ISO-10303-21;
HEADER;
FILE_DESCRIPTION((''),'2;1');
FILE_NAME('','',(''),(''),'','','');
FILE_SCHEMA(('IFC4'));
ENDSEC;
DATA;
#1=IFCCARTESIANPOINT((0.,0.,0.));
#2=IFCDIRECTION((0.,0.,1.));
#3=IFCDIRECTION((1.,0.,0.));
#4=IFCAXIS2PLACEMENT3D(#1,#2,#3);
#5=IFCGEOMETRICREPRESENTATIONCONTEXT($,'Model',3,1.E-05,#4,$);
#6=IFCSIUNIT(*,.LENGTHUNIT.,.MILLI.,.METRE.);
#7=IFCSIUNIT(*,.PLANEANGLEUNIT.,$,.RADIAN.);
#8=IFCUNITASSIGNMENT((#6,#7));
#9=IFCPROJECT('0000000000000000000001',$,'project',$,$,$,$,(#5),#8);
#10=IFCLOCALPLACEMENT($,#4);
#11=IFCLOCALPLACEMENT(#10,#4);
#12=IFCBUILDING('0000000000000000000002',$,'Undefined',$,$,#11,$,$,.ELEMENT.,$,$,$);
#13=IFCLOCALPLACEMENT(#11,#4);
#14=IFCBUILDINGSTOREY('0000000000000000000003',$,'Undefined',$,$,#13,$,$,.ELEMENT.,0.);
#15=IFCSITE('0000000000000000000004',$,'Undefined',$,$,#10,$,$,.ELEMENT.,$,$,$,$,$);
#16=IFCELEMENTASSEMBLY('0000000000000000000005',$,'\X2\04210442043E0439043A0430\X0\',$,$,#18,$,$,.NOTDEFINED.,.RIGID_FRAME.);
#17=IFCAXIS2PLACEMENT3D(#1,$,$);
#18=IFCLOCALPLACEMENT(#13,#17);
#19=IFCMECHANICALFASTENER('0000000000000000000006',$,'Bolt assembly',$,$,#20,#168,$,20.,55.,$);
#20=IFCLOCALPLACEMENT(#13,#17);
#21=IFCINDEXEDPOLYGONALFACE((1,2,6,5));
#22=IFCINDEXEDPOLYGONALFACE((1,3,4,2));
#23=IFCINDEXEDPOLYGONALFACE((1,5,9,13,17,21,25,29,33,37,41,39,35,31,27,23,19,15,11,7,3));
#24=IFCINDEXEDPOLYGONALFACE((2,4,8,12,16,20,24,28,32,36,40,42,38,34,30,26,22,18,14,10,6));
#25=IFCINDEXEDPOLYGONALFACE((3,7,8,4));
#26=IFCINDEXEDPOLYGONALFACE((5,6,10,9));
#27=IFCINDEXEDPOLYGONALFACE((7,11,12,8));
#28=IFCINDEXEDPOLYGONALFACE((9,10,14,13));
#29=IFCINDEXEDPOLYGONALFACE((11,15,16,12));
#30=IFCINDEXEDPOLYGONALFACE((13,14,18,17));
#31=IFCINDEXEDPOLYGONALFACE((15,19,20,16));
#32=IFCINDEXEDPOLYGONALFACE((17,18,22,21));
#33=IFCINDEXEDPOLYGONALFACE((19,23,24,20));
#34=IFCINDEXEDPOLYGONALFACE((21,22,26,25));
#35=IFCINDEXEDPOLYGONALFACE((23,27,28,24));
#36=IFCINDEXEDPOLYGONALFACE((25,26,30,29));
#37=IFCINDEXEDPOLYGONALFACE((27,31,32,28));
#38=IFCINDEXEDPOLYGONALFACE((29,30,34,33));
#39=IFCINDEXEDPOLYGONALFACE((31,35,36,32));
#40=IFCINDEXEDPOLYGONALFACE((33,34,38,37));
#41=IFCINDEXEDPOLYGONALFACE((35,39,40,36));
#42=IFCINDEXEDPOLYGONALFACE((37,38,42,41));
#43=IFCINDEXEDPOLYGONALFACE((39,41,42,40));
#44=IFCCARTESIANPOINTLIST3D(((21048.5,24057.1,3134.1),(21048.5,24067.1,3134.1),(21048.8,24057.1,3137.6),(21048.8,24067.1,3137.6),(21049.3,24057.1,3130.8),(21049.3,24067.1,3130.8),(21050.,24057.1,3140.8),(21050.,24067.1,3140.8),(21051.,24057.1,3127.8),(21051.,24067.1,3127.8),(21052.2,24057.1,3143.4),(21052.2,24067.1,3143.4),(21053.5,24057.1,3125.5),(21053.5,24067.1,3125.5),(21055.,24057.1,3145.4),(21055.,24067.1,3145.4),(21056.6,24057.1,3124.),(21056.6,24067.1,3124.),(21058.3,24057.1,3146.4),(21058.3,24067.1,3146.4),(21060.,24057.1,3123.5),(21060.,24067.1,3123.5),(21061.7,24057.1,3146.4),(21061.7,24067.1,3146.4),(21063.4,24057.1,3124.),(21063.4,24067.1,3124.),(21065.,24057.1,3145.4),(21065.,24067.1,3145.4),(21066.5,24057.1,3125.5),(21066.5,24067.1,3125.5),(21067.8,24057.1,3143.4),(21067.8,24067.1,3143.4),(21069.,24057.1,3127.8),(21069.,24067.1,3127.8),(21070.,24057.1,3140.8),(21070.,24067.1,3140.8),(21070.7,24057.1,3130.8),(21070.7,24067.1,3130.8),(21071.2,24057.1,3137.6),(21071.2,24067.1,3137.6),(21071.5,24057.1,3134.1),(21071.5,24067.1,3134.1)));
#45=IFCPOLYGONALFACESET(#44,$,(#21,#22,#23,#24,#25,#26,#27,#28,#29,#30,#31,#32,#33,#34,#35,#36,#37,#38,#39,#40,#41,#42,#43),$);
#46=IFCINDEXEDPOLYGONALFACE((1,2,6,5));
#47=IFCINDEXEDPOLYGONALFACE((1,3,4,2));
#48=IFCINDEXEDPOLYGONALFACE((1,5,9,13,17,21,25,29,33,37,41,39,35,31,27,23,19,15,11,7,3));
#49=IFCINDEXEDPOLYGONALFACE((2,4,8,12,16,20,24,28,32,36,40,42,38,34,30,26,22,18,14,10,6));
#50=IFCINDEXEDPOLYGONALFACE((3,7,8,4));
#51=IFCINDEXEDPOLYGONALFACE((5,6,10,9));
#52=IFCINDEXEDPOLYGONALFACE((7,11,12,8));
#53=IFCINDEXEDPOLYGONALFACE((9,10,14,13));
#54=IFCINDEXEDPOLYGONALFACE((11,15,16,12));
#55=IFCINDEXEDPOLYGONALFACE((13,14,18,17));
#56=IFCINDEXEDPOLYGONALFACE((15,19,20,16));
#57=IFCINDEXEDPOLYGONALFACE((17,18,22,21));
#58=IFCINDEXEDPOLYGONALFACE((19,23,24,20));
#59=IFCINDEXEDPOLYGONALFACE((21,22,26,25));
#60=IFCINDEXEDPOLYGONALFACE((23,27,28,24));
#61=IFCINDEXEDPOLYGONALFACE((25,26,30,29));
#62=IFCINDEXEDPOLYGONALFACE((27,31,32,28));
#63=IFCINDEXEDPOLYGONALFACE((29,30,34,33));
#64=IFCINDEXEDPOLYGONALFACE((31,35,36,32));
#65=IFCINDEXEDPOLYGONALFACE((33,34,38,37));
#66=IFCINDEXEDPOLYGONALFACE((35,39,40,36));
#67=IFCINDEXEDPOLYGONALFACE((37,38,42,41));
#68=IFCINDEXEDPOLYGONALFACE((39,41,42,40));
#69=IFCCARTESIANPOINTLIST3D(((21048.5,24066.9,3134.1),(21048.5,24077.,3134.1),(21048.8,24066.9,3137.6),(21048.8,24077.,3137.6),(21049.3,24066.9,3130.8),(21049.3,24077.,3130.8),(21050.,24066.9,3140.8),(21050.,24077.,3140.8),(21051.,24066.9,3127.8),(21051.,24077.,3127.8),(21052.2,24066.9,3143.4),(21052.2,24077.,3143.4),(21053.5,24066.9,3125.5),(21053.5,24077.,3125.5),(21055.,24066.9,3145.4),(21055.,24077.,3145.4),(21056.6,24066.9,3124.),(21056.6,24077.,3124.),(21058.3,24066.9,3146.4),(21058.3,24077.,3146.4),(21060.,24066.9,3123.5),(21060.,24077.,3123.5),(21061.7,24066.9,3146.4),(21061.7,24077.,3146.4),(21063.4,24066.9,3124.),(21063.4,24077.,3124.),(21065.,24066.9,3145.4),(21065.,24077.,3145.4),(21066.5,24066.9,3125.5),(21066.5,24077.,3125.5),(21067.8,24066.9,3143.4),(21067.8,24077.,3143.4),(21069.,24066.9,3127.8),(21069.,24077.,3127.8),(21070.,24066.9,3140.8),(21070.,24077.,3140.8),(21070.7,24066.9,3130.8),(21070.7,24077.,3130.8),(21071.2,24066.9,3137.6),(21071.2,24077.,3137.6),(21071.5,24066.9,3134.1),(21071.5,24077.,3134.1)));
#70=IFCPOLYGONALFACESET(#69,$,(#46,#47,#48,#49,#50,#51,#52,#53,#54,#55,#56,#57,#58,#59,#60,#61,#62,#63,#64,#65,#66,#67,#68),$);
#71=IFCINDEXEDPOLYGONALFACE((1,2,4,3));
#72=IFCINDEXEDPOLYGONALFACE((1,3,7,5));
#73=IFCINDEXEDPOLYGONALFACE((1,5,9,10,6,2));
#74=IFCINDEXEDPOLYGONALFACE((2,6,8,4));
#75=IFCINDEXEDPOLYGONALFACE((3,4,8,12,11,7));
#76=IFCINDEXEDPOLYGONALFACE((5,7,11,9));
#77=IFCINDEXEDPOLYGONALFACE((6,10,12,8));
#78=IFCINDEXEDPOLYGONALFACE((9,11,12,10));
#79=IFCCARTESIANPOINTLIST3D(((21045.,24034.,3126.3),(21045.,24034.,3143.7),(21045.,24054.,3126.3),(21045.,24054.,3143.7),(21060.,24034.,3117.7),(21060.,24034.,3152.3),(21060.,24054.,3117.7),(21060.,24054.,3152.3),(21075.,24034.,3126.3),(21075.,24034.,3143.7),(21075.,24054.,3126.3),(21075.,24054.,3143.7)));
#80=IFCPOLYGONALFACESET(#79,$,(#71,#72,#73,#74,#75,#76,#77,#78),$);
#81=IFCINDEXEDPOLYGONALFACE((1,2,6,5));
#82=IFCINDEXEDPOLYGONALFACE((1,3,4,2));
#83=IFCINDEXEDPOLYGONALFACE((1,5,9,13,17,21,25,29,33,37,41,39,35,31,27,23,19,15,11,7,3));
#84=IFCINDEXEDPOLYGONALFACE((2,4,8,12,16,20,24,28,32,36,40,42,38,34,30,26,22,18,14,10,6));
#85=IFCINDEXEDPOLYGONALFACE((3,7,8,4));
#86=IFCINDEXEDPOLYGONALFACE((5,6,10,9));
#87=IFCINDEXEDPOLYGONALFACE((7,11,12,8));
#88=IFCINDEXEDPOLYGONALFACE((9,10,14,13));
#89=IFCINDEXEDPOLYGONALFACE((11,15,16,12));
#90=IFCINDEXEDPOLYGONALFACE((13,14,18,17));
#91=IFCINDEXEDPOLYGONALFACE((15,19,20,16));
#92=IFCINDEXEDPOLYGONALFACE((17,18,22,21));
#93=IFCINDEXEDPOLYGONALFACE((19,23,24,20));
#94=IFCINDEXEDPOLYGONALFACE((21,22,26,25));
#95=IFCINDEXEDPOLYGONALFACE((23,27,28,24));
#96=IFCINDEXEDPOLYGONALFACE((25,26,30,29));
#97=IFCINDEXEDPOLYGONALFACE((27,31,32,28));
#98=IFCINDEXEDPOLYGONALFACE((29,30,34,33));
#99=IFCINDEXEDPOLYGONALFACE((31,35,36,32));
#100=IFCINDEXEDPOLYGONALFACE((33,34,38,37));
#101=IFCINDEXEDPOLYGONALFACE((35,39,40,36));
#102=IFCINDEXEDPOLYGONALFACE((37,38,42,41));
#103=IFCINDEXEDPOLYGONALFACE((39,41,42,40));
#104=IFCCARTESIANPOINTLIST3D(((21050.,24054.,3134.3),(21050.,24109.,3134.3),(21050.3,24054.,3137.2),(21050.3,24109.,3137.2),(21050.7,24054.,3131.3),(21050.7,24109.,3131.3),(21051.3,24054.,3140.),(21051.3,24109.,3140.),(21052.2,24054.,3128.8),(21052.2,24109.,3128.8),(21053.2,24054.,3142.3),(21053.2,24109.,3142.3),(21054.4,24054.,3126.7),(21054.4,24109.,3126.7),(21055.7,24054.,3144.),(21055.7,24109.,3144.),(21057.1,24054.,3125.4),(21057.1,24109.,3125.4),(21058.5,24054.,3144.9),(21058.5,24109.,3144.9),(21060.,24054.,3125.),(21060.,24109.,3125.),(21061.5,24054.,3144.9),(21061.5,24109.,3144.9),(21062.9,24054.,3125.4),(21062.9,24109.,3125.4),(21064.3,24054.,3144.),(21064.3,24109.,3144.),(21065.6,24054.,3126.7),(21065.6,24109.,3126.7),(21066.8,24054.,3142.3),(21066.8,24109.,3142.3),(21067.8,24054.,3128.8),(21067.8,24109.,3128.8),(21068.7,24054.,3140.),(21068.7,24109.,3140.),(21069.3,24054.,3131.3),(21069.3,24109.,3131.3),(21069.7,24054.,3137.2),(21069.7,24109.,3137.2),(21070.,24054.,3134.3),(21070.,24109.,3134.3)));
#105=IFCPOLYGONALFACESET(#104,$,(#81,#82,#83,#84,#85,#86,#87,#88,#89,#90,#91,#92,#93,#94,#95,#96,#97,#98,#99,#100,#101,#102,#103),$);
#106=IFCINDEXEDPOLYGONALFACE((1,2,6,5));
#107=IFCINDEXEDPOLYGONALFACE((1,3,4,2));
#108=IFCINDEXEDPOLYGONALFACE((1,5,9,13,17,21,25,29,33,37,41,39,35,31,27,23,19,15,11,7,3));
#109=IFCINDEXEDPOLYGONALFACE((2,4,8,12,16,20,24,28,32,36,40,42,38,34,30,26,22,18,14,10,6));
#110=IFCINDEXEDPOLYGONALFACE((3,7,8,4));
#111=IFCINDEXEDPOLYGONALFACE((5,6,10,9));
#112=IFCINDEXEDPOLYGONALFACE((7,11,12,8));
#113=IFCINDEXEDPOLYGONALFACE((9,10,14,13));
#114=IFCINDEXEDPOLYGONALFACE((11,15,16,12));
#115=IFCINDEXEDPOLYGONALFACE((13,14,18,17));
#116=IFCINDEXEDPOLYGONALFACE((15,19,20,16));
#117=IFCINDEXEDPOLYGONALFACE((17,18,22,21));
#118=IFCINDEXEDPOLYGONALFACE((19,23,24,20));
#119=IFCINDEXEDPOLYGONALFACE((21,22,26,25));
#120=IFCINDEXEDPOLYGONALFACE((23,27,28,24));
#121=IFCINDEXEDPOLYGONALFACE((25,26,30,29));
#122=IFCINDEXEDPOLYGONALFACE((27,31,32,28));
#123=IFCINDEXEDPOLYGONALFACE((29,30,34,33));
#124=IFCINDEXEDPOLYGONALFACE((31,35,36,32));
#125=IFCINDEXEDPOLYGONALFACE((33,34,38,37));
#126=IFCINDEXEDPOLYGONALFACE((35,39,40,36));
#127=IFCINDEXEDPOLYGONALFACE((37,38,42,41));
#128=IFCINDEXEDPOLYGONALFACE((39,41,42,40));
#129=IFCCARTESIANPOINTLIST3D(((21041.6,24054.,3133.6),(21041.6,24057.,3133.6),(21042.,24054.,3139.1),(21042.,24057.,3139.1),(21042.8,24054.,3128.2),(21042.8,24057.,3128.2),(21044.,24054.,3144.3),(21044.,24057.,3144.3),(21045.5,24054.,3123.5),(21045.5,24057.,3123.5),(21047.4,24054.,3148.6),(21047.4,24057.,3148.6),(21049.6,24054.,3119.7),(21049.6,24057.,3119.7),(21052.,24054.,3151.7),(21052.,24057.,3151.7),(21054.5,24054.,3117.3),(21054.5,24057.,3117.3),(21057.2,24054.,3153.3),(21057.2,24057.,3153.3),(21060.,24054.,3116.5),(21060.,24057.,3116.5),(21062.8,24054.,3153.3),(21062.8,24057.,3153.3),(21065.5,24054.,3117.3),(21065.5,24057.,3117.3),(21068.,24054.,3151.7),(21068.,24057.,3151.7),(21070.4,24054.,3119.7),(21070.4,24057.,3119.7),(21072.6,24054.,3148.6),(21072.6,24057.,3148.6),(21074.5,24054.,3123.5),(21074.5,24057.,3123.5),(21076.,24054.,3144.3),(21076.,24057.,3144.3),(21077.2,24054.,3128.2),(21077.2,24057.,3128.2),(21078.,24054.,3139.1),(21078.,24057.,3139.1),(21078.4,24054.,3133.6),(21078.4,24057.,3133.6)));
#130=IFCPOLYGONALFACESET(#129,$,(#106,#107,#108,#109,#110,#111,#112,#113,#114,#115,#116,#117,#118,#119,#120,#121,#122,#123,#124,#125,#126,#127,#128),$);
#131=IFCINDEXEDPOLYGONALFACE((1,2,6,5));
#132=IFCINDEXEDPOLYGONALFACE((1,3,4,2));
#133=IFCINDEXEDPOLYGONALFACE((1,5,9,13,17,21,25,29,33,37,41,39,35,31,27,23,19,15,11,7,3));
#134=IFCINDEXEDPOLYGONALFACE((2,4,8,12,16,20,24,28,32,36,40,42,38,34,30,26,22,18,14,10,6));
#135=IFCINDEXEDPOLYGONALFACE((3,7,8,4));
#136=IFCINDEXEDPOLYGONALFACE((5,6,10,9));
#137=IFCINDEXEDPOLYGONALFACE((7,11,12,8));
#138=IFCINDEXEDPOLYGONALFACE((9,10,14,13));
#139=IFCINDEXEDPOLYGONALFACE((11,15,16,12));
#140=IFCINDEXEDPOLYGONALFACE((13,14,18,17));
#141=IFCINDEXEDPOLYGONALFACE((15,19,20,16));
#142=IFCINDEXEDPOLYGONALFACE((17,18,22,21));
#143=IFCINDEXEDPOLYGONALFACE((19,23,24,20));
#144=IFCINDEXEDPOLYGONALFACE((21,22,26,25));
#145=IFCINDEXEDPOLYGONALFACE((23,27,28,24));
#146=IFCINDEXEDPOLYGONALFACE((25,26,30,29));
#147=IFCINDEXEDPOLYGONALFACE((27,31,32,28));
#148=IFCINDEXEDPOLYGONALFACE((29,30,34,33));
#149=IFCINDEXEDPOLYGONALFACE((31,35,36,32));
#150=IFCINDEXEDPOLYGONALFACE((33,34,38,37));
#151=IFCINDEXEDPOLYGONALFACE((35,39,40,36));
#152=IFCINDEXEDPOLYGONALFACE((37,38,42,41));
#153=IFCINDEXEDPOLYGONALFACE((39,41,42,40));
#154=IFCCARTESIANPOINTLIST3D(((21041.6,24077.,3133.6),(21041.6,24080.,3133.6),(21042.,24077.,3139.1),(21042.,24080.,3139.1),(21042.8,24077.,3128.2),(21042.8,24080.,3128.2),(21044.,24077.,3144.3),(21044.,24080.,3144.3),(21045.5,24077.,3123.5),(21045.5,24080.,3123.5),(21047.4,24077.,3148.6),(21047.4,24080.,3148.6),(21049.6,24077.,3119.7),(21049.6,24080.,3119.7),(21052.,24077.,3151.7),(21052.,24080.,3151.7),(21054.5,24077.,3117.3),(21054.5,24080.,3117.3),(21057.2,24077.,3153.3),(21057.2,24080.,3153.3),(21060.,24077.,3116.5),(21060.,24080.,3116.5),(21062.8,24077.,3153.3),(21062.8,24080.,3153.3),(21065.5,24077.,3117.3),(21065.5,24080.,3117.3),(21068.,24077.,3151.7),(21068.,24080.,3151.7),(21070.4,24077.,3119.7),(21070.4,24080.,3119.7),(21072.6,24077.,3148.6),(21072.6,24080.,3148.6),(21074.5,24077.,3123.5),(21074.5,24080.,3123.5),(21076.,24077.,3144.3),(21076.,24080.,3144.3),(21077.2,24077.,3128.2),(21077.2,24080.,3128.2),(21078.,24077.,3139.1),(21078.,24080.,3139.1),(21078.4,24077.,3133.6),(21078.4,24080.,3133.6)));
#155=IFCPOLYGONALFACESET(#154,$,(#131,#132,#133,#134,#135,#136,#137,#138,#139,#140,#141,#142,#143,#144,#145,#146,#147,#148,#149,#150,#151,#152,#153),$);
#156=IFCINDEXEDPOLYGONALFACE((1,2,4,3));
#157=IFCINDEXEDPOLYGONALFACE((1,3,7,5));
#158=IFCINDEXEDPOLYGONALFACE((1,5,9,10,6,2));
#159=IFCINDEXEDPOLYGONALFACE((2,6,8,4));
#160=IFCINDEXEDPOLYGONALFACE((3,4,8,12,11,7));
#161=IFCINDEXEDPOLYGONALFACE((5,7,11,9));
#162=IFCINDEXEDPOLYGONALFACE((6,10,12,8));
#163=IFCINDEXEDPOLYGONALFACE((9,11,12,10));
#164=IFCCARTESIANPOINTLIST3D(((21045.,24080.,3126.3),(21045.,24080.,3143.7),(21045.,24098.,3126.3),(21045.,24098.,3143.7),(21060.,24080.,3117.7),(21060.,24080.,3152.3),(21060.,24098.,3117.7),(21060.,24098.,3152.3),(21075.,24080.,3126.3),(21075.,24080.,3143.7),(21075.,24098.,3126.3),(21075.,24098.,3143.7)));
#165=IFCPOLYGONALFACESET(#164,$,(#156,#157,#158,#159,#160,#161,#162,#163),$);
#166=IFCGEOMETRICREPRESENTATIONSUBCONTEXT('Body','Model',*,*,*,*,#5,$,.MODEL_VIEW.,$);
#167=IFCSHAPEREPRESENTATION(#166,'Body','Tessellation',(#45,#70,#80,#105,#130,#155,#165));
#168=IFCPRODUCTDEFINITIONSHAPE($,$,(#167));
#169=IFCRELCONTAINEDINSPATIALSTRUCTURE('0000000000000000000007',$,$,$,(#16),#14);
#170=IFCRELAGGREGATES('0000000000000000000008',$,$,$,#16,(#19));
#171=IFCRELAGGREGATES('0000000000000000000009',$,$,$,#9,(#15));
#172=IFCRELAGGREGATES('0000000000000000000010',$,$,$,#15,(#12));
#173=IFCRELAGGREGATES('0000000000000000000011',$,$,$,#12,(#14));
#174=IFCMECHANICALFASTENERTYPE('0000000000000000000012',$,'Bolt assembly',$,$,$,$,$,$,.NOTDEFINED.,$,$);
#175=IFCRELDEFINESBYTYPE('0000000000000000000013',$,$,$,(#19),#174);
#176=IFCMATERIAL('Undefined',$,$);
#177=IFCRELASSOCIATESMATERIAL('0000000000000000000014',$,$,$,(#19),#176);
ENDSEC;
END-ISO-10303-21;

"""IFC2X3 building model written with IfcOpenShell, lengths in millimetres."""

from ifc_helpers import new_model, si_unit, frame, origin_with_axes, origin_2d_with_axis, place, context, subcontext, project, spatial, polyline, circle, outline, extrude, source, transform, mapped, material, type_object, element, aggregate, save


model = new_model("IFC2X3")

# Units and contexts
model_context = context("Model", 3, precision=1e-05, world=origin_with_axes())
body_context = subcontext(model_context, "Body", "Model", "MODEL_VIEW")
ifc_project = project(units=[si_unit("LENGTHUNIT", "METRE", prefix="MILLI"), si_unit("PLANEANGLEUNIT", "RADIAN")], contexts=[model_context])

# Site, building, storey
site_placement = place(None, origin_with_axes())
site = spatial("IfcSite", under=ifc_project, at=site_placement, Name="Undefined", CompositionType="ELEMENT")
building_placement = place(site_placement, origin_with_axes())
building = spatial("IfcBuilding", under=site, at=building_placement, Name="Undefined", CompositionType="ELEMENT")
storey_placement = place(building_placement, origin_with_axes())
storey = spatial("IfcBuildingStorey", under=building, at=storey_placement, Name="Undefined", CompositionType="ELEMENT", Elevation=0.0)

# Element assembly
assembly_1_placement = place(storey_placement, origin_with_axes())
assembly_1 = element("IfcElementAssembly", 1, at=assembly_1_placement, inside=storey, Name="Стойка", AssemblyPlace="NOTDEFINED", PredefinedType="RIGID_FRAME")

# Mechanical fastener
ifc_material_1 = material(Name="Undefined")
mechanical_fastener_type = type_object("IfcMechanicalFastenerType", Name="Bolt assembly")
shared_shape = source(origin_with_axes(), body_context, "Body", "SweptSolid", [
    extrude(circle(Radius=11.5, at=origin_2d_with_axis()), frame((0.0, 0.1, 0.0), z_axis=(0.0, 1.0, 0.0), x_axis=(1.0, 0.0, 0.0)), (0.0, 0.0, 1.0), 10.0),
    extrude(circle(Radius=11.5, at=origin_2d_with_axis()), frame((0.0, 9.9, 0.0), z_axis=(0.0, 1.0, 0.0), x_axis=(1.0, 0.0, 0.0)), (0.0, 0.0, 1.0), 10.1),
    extrude(outline(polyline([(17.3, 0.0), (8.7, 15.0), (-8.7, 15.0), (-17.3, 0.0), (-8.7, -15.0), (8.7, -15.0), (17.3, 0.0)])), frame((0.0, -23.0, 0.0), z_axis=(0.0, 1.0, 0.0), x_axis=(1.0, 0.0, 0.0)), (0.0, 0.0, 1.0), 20.0),
    extrude(circle(Radius=10.0, at=origin_2d_with_axis()), frame((0.0, -3.0, 0.0), z_axis=(0.0, 1.0, 0.0), x_axis=(1.0, 0.0, 0.0)), (0.0, 0.0, 1.0), 55.0),
    extrude(circle(Radius=18.5, at=origin_2d_with_axis()), frame((0.0, -3.0, 0.0), z_axis=(0.0, 1.0, 0.0), x_axis=(1.0, 0.0, 0.0)), (0.0, 0.0, 1.0), 3.0),
    extrude(circle(Radius=18.5, at=origin_2d_with_axis()), frame((0.0, 20.0, 0.0), z_axis=(0.0, 1.0, 0.0), x_axis=(1.0, 0.0, 0.0)), (0.0, 0.0, 1.0), 3.0),
    extrude(outline(polyline([(17.3, 0.0), (8.7, 15.0), (-8.7, 15.0), (-17.3, 0.0), (-8.7, -15.0), (8.7, -15.0), (17.3, 0.0)])), frame((0.0, 23.0, 0.0), z_axis=(0.0, 1.0, 0.0), x_axis=(1.0, 0.0, 0.0)), (0.0, 0.0, 1.0), 18.0),
])
mechanical_fastener_1_placement = place(assembly_1_placement, frame((21060.0, 24057.0, 3135.0), z_axis=(1.0, 0.0, 0.0), x_axis=(0.0, 0.0, -1.0)))
mechanical_fastener_1 = element("IfcMechanicalFastener", 2, at=mechanical_fastener_1_placement, type_object=mechanical_fastener_type, material=ifc_material_1, Name="Bolt assembly", NominalDiameter=20.0, NominalLength=55.0, context=body_context, shape_type="MappedRepresentation", body=[
    mapped(shared_shape, transform((0.0, 0.0, 0.0))),
])
aggregate(assembly_1, [mechanical_fastener_1])

save(model, "model.ifc")
